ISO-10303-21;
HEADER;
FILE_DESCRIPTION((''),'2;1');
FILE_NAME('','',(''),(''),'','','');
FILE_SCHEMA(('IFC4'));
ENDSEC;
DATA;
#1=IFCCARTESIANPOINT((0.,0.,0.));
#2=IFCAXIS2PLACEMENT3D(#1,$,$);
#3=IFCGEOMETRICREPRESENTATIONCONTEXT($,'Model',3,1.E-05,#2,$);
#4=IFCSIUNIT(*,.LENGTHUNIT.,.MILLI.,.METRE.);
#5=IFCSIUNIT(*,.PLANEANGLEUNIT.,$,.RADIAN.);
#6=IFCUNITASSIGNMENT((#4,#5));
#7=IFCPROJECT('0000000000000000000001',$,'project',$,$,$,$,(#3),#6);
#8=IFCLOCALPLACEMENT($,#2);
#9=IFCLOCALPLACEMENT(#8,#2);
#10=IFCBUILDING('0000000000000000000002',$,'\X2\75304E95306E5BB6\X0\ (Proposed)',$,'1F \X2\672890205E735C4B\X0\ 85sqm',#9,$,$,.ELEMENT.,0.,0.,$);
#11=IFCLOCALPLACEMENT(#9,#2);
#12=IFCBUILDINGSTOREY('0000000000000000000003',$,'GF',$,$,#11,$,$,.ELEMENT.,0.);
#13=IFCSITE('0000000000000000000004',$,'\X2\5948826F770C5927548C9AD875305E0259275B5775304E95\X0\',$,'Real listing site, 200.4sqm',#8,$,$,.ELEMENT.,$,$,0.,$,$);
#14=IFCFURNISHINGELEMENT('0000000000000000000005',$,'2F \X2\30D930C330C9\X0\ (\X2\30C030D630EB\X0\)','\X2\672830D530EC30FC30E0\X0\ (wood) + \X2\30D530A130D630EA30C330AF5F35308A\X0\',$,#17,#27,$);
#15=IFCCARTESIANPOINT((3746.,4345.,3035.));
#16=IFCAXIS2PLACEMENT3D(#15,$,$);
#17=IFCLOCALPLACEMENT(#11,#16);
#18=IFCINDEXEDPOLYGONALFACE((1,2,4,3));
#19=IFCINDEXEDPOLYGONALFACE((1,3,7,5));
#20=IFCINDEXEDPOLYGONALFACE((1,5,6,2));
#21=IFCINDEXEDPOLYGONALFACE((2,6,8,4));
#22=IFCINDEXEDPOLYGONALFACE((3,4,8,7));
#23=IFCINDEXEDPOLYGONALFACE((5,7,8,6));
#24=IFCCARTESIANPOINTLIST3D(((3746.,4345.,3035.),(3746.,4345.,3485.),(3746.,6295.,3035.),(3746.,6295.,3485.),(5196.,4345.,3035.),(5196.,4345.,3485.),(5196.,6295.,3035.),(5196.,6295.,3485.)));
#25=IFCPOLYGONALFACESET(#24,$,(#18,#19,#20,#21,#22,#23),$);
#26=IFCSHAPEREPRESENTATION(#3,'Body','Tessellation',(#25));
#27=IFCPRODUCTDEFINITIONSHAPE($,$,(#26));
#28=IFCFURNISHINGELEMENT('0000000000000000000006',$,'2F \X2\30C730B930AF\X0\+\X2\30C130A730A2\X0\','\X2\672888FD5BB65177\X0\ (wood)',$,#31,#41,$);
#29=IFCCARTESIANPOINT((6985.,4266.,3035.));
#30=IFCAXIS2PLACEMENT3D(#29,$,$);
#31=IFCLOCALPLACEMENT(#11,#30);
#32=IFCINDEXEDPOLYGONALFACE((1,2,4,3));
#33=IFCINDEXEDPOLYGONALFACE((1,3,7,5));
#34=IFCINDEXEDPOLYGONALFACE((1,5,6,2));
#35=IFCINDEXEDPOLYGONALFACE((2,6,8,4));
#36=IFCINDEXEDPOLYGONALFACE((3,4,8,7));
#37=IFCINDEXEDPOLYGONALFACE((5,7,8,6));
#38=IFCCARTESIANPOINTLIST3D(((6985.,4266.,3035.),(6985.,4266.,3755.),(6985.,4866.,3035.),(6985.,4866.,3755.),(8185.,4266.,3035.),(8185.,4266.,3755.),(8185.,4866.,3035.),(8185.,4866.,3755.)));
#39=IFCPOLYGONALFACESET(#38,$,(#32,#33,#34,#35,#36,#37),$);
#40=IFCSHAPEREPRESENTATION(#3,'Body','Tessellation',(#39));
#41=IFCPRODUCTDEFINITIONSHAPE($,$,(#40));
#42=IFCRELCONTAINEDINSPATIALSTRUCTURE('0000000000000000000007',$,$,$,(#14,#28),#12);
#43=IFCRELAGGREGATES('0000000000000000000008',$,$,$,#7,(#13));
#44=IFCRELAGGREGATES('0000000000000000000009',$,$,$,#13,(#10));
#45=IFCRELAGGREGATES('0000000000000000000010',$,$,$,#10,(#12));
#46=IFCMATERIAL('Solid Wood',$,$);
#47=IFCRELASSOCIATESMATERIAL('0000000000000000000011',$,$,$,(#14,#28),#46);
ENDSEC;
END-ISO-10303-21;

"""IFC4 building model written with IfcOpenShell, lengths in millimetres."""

from ifc_helpers import new_model, si_unit, frame, frame_2d, origin, place, context, project, spatial, rectangle, extrude, material, element, save


model = new_model("IFC4")

# Units and contexts
model_context = context("Model", 3, precision=1e-05, world=origin())
ifc_project = project(units=[si_unit("LENGTHUNIT", "METRE", prefix="MILLI"), si_unit("PLANEANGLEUNIT", "RADIAN")], contexts=[model_context])

# Site, building, storey
site_placement = place(None, origin())
site = spatial("IfcSite", under=ifc_project, at=site_placement, Name="奈良県大和高田市大字田井", ObjectType="Real listing site, 200.4sqm", CompositionType="ELEMENT", RefElevation=0.0)
building_placement = place(site_placement, origin())
building = spatial("IfcBuilding", under=site, at=building_placement, Name="田井の家 (Proposed)", ObjectType="1F 木造平屋 85sqm", CompositionType="ELEMENT", ElevationOfRefHeight=0.0, ElevationOfTerrain=0.0)
storey_placement = place(building_placement, origin())
storey = spatial("IfcBuildingStorey", under=building, at=storey_placement, Name="GF", CompositionType="ELEMENT", Elevation=0.0)

# Shared definitions
ifc_material_1 = material(Name="Solid Wood")

# Furnishing elements
furnishing_1_placement = place(storey_placement, frame((3746.0, 4345.0, 3035.0)))
element("IfcFurnishingElement", 1, at=furnishing_1_placement, inside=storey, material=ifc_material_1, Name="2F ベッド (ダブル)", Description="木フレーム (wood) + ファブリック張り", context=model_context, shape_type="SweptSolid", body=[
    extrude(rectangle(XDim=1450.0, YDim=1950.0, at=frame_2d((725.0, 975.0))), frame((3746.0, 4345.0, 3035.0)), (0.0, 0.0, 1.0), 450.0),
])
furnishing_2_placement = place(storey_placement, frame((6985.0, 4266.0, 3035.0)))
element("IfcFurnishingElement", 2, at=furnishing_2_placement, inside=storey, material=ifc_material_1, Name="2F デスク+チェア", Description="木製家具 (wood)", context=model_context, shape_type="SweptSolid", body=[
    extrude(rectangle(XDim=1200.0, YDim=600.0, at=frame_2d((600.0, 300.0))), frame((6985.0, 4266.0, 3035.0)), (0.0, 0.0, 1.0), 720.0),
])

save(model, "model.ifc")
